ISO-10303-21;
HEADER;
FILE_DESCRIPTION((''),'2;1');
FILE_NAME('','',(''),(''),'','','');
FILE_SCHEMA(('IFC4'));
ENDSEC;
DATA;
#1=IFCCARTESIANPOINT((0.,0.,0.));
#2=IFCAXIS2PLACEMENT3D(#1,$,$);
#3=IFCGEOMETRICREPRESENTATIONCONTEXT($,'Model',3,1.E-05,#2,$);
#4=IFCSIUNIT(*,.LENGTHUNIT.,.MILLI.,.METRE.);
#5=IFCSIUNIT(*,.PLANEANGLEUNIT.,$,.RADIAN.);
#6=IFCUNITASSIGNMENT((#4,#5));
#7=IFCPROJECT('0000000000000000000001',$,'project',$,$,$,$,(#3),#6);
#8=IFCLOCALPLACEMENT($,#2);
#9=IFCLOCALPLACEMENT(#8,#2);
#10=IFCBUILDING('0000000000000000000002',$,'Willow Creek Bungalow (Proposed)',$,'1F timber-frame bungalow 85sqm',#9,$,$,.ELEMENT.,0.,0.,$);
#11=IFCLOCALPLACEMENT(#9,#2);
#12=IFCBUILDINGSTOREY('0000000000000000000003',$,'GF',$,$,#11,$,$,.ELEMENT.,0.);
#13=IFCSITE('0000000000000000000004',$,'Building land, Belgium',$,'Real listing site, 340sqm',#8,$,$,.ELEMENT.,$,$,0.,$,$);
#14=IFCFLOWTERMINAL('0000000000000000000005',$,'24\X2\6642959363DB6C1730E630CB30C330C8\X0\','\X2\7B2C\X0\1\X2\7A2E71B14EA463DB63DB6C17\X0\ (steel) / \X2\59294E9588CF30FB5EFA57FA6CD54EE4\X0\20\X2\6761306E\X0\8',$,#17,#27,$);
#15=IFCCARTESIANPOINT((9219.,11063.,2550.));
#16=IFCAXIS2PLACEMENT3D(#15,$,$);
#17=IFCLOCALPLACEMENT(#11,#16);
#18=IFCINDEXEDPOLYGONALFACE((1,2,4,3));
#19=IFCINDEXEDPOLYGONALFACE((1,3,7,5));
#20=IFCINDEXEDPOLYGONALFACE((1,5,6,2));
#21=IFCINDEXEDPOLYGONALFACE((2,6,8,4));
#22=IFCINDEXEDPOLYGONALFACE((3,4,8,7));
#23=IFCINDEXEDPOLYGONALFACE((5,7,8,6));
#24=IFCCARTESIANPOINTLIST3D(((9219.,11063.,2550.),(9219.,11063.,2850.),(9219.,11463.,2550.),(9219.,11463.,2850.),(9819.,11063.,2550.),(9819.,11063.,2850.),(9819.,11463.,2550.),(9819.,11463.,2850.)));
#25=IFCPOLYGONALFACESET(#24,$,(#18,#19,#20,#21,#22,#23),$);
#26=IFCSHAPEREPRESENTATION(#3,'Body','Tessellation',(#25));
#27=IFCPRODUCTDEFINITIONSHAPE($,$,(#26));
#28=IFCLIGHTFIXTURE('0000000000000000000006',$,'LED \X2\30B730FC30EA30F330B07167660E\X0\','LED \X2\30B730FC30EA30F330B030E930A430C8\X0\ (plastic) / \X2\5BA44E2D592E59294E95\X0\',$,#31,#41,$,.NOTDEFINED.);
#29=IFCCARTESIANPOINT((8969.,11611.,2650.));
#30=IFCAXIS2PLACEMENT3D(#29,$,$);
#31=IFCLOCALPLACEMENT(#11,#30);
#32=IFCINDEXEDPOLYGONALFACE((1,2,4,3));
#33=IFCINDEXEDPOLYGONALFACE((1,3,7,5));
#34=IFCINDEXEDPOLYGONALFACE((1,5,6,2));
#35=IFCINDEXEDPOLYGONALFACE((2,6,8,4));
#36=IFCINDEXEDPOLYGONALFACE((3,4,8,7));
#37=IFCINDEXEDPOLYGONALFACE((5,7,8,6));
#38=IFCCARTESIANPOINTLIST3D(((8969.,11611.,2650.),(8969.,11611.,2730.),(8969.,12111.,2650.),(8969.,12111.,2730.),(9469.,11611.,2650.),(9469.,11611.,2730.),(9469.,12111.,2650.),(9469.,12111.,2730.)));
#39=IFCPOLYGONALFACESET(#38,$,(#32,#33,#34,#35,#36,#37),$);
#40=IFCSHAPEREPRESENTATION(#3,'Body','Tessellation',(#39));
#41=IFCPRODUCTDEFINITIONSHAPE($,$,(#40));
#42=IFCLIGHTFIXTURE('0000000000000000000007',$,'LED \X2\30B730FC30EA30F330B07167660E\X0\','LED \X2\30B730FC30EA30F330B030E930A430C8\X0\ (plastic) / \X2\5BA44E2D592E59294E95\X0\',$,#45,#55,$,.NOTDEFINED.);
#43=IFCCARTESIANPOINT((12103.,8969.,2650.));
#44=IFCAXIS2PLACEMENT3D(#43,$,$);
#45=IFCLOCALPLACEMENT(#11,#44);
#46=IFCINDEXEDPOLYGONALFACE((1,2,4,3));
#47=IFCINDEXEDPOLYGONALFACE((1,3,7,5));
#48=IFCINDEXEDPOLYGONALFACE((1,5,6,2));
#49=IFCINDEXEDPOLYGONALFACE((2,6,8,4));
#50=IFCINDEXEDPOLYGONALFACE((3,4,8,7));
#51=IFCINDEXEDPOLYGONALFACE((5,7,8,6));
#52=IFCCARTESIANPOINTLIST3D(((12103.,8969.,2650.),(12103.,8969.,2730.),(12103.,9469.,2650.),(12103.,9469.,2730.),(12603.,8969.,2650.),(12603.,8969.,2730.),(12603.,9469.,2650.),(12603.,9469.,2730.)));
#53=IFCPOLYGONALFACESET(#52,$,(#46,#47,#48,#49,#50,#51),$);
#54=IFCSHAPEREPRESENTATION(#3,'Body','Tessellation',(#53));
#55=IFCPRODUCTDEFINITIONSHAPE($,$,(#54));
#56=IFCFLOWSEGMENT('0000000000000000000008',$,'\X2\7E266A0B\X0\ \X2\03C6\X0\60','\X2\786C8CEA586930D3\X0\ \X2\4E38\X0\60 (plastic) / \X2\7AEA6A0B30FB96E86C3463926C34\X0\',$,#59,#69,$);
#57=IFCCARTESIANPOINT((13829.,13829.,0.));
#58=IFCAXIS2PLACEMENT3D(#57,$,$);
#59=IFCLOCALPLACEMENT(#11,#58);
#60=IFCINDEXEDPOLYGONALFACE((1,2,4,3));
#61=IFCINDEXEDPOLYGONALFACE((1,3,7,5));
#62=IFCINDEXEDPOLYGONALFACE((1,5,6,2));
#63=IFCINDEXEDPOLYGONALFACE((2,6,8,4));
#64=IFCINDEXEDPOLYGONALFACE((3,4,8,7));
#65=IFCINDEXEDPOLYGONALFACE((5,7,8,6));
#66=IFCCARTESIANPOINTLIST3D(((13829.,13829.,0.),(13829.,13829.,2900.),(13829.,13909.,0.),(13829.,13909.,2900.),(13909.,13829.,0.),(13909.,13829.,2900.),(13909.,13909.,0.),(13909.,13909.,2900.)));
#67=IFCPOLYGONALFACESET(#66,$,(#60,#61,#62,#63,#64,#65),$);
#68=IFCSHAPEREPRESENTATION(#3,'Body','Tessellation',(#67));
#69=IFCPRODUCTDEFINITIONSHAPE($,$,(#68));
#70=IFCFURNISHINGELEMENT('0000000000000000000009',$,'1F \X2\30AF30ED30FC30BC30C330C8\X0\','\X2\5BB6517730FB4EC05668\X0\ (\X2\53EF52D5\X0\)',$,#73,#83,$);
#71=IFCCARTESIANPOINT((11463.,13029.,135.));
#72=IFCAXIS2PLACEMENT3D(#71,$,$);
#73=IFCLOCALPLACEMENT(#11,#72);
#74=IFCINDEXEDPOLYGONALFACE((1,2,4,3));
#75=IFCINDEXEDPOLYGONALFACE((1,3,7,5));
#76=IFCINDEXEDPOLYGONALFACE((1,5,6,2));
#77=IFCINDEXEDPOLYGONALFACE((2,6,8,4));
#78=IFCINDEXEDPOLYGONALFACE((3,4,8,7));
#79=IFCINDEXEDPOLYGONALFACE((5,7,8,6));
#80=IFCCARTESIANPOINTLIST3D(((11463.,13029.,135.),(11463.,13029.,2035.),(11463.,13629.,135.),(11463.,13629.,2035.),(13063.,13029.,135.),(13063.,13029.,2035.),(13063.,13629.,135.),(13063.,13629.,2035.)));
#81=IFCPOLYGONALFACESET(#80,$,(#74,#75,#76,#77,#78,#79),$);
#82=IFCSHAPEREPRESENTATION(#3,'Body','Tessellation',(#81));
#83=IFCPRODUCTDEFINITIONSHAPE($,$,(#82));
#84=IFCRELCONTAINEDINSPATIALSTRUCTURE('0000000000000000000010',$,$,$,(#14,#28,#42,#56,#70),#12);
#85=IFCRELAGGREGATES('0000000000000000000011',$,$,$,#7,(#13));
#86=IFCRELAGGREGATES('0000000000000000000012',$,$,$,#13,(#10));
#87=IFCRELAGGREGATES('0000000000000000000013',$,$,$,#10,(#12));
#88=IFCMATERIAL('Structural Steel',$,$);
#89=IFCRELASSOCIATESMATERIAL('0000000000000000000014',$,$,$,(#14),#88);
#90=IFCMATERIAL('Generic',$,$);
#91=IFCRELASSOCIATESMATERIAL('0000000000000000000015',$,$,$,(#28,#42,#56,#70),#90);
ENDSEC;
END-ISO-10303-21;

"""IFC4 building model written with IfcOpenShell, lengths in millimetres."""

from ifc_helpers import new_model, si_unit, frame, frame_2d, origin, place, context, project, spatial, rectangle, extrude, material, element, save


model = new_model("IFC4")

# Units and contexts
model_context = context("Model", 3, precision=1e-05, world=origin())
ifc_project = project(units=[si_unit("LENGTHUNIT", "METRE", prefix="MILLI"), si_unit("PLANEANGLEUNIT", "RADIAN")], contexts=[model_context])

# Site, building, storey
site_placement = place(None, origin())
site = spatial("IfcSite", under=ifc_project, at=site_placement, Name="Building land, Belgium", ObjectType="Real listing site, 340sqm", CompositionType="ELEMENT", RefElevation=0.0)
building_placement = place(site_placement, origin())
building = spatial("IfcBuilding", under=site, at=building_placement, Name="Willow Creek Bungalow (Proposed)", ObjectType="1F timber-frame bungalow 85sqm", CompositionType="ELEMENT", ElevationOfRefHeight=0.0, ElevationOfTerrain=0.0)
storey_placement = place(building_placement, origin())
storey = spatial("IfcBuildingStorey", under=building, at=storey_placement, Name="GF", CompositionType="ELEMENT", Elevation=0.0)

# Shared definitions
ifc_material_1 = material(Name="Generic")

# Flow terminal
ifc_material_2 = material(Name="Structural Steel")
flow_terminal_placement = place(storey_placement, frame((9219.0, 11063.0, 2550.0)))
element("IfcFlowTerminal", 1, at=flow_terminal_placement, inside=storey, material=ifc_material_2, Name="24時間換気ユニット", Description="第1種熱交換換気 (steel) / 天井裏・建基法令20条の8", context=model_context, shape_type="SweptSolid", body=[
    extrude(rectangle(XDim=600.0, YDim=400.0, at=frame_2d((300.0, 200.0))), frame((9219.0, 11063.0, 2550.0)), (0.0, 0.0, 1.0), 300.0),
])

# Light fixtures
light_fixture_1_placement = place(storey_placement, frame((8969.0, 11611.0, 2650.0)))
element("IfcLightFixture", 2, at=light_fixture_1_placement, inside=storey, material=ifc_material_1, Name="LED シーリング照明", Description="LED シーリングライト (plastic) / 室中央天井", PredefinedType="NOTDEFINED", context=model_context, shape_type="SweptSolid", body=[
    extrude(rectangle(XDim=500.0, YDim=500.0, at=frame_2d((250.0, 250.0))), frame((8969.0, 11611.0, 2650.0)), (0.0, 0.0, 1.0), 80.0),
])
light_fixture_2_placement = place(storey_placement, frame((12103.0, 8969.0, 2650.0)))
element("IfcLightFixture", 3, at=light_fixture_2_placement, inside=storey, material=ifc_material_1, Name="LED シーリング照明", Description="LED シーリングライト (plastic) / 室中央天井", PredefinedType="NOTDEFINED", context=model_context, shape_type="SweptSolid", body=[
    extrude(rectangle(XDim=500.0, YDim=500.0, at=frame_2d((250.0, 250.0))), frame((12103.0, 8969.0, 2650.0)), (0.0, 0.0, 1.0), 80.0),
])

# Flow segment
flow_segment_placement = place(storey_placement, frame((13829.0, 13829.0, 0.0)))
element("IfcFlowSegment", 4, at=flow_segment_placement, inside=storey, material=ifc_material_1, Name="縦樋 φ60", Description="硬質塩ビ 丸60 (plastic) / 竪樋・雨水排水", context=model_context, shape_type="SweptSolid", body=[
    extrude(rectangle(XDim=80.0, YDim=80.0, at=frame_2d((40.0, 40.0))), frame((13829.0, 13829.0, 0.0)), (0.0, 0.0, 1.0), 2900.0),
])

# Furnishing element
furnishing_placement = place(storey_placement, frame((11463.0, 13029.0, 135.0)))
element("IfcFurnishingElement", 5, at=furnishing_placement, inside=storey, material=ifc_material_1, Name="1F クローゼット", Description="家具・什器 (可動)", context=model_context, shape_type="SweptSolid", body=[
    extrude(rectangle(XDim=1600.0, YDim=600.0, at=frame_2d((800.0, 300.0))), frame((11463.0, 13029.0, 135.0)), (0.0, 0.0, 1.0), 1900.0),
])

save(model, "model.ifc")
